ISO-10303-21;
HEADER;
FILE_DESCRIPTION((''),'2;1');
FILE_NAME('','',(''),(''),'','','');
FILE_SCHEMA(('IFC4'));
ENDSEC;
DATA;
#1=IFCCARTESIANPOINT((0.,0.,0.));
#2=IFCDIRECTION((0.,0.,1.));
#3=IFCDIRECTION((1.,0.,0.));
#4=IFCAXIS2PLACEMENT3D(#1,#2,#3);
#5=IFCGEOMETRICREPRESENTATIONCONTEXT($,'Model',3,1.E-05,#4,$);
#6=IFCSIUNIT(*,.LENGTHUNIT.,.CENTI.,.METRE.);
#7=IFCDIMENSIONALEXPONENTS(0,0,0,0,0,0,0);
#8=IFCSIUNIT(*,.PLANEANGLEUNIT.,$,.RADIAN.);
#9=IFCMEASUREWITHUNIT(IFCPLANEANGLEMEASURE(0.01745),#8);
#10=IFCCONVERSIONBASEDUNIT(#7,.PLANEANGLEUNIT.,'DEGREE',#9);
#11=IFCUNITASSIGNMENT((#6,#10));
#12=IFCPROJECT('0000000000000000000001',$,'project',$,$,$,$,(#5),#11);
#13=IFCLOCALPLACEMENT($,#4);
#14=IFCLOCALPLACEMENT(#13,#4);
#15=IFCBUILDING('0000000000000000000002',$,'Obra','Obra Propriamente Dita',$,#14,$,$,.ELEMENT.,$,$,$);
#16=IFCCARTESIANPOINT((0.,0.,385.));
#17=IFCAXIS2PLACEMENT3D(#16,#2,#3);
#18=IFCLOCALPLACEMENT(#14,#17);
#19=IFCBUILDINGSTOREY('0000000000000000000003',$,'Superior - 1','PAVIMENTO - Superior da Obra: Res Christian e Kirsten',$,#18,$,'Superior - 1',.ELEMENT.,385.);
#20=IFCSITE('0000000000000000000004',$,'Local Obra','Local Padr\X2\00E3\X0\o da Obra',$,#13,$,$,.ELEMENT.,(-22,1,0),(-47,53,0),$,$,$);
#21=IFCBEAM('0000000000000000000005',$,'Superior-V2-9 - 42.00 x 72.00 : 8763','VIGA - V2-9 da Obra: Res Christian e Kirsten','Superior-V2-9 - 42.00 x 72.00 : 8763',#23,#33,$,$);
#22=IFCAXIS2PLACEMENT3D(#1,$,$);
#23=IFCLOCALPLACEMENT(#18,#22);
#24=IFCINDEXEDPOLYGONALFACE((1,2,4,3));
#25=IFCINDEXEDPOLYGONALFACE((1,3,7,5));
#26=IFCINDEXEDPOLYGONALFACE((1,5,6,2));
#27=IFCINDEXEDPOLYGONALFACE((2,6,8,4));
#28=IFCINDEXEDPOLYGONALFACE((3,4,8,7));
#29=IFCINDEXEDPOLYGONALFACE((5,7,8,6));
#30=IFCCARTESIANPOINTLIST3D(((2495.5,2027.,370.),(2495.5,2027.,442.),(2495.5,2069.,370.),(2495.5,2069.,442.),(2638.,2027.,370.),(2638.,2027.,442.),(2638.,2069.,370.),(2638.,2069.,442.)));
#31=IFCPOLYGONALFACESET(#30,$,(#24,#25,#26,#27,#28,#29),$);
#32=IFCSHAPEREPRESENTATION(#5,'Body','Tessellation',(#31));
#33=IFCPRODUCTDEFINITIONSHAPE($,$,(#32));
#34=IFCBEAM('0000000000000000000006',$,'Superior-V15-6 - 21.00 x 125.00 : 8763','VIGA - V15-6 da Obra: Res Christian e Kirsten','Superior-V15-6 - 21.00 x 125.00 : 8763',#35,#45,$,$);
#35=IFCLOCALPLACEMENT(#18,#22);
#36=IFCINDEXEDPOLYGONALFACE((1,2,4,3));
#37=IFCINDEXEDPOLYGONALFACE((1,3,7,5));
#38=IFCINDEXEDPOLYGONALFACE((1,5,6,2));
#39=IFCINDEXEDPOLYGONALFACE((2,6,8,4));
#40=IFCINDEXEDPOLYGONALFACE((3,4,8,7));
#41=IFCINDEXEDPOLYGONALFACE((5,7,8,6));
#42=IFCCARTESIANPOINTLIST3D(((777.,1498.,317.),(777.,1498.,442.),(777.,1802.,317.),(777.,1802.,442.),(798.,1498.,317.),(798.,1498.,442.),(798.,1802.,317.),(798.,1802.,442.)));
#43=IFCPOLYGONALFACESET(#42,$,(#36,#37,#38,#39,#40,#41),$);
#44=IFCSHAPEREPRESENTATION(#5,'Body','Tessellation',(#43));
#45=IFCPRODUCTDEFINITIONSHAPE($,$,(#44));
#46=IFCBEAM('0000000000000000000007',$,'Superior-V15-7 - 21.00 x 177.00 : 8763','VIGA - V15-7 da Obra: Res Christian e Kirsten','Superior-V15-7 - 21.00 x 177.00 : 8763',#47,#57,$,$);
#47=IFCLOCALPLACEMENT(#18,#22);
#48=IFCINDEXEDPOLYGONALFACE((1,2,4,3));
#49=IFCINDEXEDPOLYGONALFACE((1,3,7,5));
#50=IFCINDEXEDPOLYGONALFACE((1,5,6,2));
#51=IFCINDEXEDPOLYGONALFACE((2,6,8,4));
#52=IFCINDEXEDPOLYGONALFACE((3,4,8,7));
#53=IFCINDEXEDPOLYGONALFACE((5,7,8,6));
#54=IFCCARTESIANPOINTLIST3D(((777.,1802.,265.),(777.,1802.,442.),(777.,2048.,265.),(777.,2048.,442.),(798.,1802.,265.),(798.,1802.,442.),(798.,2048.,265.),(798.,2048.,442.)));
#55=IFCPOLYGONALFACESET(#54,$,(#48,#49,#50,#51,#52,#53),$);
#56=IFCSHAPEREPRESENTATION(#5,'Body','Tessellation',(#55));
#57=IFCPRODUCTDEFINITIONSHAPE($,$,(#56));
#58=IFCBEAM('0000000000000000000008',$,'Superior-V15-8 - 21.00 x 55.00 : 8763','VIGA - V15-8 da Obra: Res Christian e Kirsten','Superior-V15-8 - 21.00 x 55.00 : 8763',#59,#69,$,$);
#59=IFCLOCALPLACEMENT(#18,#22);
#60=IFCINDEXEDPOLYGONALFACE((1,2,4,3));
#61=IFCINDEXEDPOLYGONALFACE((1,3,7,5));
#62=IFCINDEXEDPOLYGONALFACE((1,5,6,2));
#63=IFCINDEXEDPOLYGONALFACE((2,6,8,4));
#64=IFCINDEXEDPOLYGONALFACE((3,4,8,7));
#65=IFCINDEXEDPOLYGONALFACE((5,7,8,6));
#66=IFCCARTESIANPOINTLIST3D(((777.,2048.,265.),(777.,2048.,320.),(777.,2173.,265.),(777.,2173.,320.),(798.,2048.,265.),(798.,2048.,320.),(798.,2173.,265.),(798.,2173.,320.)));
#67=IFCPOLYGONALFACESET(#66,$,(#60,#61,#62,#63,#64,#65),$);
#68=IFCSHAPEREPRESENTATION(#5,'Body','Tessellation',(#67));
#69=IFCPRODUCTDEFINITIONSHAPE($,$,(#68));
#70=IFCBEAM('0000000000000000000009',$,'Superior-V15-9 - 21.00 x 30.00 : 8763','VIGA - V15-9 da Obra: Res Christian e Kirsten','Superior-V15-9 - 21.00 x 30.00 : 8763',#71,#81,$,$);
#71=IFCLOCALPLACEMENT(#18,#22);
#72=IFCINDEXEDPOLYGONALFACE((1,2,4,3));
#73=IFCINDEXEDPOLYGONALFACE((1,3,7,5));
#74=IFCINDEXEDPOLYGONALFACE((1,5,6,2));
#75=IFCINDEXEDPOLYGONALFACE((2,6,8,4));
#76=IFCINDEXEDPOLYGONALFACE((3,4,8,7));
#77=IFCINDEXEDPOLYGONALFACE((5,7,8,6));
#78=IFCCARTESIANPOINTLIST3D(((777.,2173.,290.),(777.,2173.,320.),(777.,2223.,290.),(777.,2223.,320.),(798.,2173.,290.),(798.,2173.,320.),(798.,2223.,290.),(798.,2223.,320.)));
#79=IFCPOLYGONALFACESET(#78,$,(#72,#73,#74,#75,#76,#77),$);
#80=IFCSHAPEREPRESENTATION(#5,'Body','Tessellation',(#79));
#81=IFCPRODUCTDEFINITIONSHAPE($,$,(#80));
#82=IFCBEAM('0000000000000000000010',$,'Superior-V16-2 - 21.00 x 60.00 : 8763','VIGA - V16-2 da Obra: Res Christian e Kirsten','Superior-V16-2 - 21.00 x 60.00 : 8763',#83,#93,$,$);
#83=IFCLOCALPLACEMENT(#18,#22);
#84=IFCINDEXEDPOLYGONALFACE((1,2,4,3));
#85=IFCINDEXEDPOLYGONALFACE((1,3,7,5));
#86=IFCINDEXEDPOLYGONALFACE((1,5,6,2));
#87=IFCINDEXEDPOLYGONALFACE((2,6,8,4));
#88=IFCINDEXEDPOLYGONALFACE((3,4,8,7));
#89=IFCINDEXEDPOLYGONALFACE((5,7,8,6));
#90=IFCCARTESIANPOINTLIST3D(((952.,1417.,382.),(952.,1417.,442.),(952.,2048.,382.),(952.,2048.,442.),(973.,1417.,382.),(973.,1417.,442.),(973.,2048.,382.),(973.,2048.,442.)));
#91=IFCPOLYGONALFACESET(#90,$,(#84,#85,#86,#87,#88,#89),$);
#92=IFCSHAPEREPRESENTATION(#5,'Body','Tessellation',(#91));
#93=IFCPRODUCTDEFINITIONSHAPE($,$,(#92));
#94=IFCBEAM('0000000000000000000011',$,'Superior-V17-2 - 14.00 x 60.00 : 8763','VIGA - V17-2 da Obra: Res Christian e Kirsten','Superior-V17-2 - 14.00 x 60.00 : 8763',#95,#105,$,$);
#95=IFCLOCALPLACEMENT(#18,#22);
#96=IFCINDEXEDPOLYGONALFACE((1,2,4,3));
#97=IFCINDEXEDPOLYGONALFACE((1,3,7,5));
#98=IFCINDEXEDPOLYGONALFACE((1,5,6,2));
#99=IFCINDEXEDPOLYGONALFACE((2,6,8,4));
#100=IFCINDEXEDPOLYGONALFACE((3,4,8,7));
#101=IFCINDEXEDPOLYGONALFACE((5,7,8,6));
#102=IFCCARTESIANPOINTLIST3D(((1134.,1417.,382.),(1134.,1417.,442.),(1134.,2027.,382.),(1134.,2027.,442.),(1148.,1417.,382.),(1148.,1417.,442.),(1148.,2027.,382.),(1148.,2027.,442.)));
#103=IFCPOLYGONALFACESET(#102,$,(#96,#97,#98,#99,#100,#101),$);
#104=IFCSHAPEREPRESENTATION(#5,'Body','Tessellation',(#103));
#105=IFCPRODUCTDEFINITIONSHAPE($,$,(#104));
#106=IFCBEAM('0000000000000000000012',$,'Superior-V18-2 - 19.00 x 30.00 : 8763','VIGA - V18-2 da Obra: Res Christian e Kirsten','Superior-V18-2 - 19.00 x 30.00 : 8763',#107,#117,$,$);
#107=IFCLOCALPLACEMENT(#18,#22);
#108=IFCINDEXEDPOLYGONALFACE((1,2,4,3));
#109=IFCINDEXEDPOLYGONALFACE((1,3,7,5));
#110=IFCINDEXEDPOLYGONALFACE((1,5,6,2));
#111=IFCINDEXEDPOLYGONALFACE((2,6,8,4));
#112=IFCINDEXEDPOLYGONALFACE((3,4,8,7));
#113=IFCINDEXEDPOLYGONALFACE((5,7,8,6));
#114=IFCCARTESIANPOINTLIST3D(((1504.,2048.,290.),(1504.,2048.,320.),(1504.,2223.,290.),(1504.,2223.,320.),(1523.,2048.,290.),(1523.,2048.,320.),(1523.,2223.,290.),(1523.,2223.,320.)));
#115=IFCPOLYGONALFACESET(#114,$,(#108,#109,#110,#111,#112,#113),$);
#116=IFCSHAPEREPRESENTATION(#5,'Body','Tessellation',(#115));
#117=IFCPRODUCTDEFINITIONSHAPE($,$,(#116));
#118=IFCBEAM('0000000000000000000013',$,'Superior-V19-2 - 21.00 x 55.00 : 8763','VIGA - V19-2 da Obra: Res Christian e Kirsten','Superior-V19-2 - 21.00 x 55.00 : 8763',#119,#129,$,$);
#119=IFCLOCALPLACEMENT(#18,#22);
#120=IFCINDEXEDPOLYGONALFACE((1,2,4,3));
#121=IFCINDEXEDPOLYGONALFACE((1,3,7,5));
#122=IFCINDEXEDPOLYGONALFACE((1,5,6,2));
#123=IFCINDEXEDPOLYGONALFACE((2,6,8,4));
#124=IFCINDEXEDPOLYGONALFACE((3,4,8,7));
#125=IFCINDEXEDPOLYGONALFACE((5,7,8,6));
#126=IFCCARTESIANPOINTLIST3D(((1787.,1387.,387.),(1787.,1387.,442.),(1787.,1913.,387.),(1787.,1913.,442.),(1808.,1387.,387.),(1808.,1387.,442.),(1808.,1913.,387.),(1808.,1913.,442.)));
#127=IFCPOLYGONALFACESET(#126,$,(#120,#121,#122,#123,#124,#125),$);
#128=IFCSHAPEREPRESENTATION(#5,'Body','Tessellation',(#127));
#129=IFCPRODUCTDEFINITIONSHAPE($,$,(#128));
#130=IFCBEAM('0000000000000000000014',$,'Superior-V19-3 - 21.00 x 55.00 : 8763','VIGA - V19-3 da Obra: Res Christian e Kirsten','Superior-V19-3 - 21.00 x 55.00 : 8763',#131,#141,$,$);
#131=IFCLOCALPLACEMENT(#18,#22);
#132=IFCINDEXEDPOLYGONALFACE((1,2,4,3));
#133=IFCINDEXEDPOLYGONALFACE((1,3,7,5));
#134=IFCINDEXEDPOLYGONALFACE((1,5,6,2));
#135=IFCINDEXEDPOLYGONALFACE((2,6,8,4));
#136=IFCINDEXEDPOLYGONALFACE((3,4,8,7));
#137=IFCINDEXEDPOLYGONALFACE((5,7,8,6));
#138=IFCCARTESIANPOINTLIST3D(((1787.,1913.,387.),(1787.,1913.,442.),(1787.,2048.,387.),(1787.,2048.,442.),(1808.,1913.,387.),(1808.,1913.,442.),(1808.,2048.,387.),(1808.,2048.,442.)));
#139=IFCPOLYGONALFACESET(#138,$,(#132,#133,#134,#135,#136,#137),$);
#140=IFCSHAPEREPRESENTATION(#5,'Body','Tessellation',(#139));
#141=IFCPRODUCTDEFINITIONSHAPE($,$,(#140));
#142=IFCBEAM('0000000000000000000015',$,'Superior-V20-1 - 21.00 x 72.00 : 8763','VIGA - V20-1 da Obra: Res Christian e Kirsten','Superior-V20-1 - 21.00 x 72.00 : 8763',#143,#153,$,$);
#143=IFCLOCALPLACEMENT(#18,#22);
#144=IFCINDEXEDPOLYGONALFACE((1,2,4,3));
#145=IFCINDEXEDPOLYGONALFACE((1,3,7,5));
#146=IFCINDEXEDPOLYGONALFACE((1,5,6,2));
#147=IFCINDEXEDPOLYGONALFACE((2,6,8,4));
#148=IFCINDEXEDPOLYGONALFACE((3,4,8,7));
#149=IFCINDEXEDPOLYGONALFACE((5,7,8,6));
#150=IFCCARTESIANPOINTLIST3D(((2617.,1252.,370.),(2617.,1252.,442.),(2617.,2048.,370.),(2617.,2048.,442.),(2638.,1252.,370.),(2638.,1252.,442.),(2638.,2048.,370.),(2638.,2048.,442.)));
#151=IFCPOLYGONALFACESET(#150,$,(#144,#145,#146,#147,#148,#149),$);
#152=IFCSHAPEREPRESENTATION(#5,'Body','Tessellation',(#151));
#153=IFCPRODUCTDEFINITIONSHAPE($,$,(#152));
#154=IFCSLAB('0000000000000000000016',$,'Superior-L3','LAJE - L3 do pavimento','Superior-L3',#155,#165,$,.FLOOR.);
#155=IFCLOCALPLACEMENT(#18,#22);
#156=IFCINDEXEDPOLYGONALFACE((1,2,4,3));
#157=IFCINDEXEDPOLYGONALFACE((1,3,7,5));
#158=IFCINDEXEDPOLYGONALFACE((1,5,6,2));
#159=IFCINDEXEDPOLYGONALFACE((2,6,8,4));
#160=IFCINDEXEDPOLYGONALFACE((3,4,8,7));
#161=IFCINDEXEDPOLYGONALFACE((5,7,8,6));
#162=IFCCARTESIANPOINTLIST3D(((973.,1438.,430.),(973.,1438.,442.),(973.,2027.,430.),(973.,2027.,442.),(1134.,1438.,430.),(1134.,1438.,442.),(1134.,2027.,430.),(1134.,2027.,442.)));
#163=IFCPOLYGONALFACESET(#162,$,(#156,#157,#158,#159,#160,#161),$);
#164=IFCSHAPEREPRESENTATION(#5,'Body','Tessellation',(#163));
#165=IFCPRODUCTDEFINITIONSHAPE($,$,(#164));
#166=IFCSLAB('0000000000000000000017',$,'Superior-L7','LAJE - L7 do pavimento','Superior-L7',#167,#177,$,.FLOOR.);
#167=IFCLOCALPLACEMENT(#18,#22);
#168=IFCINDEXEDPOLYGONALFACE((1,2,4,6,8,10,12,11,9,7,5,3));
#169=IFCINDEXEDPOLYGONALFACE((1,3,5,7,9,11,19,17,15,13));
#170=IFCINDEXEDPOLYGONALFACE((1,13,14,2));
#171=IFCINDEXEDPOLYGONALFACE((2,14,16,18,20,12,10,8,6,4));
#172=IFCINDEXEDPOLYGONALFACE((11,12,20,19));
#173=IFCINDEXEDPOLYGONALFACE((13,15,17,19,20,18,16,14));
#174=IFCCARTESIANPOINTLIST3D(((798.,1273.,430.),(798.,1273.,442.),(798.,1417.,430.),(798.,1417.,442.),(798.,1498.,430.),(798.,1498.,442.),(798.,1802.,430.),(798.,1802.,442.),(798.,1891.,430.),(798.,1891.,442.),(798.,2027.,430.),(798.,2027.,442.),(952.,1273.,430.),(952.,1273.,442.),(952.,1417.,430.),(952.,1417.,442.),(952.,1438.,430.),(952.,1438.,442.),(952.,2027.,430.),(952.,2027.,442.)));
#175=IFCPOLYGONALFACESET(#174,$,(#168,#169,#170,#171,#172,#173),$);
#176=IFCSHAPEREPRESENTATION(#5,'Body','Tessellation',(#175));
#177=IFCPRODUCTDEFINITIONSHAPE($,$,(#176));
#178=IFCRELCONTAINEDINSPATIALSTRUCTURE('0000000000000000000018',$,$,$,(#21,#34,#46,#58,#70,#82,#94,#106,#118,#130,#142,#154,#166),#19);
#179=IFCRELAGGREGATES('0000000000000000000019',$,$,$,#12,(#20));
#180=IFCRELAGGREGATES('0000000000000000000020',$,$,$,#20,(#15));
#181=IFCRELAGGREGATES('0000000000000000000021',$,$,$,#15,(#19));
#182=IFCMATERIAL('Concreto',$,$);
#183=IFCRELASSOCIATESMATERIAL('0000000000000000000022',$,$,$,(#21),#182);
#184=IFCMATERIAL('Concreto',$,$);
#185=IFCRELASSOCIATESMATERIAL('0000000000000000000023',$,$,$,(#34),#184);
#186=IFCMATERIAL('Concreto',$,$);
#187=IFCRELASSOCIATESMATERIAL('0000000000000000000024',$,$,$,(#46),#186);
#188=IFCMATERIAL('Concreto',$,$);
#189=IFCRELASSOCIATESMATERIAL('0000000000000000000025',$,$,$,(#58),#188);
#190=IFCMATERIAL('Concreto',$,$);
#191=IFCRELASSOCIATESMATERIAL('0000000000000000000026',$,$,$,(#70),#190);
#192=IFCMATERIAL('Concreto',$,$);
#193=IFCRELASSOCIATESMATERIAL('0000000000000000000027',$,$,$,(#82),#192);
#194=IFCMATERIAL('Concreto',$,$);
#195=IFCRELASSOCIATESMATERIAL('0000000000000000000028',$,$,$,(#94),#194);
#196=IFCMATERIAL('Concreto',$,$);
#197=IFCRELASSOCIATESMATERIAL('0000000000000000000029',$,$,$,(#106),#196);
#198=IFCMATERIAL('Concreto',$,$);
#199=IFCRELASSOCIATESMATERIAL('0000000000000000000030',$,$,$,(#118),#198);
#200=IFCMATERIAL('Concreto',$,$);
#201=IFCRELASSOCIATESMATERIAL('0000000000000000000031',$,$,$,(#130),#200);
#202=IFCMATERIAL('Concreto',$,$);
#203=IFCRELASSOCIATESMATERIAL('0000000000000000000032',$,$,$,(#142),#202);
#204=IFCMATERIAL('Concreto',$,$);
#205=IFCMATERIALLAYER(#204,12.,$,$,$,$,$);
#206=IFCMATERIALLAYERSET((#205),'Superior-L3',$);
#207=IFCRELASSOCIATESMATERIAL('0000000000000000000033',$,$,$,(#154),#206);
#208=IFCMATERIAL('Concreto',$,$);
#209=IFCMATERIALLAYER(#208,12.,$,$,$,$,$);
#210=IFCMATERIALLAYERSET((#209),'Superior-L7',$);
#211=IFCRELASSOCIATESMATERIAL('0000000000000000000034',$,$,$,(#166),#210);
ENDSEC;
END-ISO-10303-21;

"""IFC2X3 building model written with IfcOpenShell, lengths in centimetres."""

from ifc_helpers import new_model, entity, si_unit, converted_unit, frame, origin_with_axes, place, context, project, spatial, polyline, outline, extrude, material, layer, layer_set, layer_usage, element, save


model = new_model("IFC2X3")

# Units and contexts
model_context = context("Model", 3, precision=1e-05, world=origin_with_axes())
ifc_project = project(units=[si_unit("LENGTHUNIT", "METRE", prefix="CENTI"), converted_unit("PLANEANGLEUNIT", "DEGREE", entity("IfcPlaneAngleMeasure", 0.01745), si_unit("PLANEANGLEUNIT", "RADIAN"), dimensions=[0, 0, 0, 0, 0, 0, 0])], contexts=[model_context])

# Site, building, storey
site_placement = place(None, origin_with_axes())
site = spatial("IfcSite", under=ifc_project, at=site_placement, Name="Local Obra", Description="Local Padrão da Obra", CompositionType="ELEMENT", RefLatitude=(-22, 1, 0), RefLongitude=(-47, 53, 0))
building_placement = place(site_placement, origin_with_axes())
building = spatial("IfcBuilding", under=site, at=building_placement, Name="Obra", Description="Obra Propriamente Dita", CompositionType="ELEMENT")
storey_placement = place(building_placement, frame((0.0, 0.0, 385.0), z_axis=(0.0, 0.0, 1.0), x_axis=(1.0, 0.0, 0.0)))
storey = spatial("IfcBuildingStorey", under=building, at=storey_placement, Name="Superior - 1", Description="PAVIMENTO - Superior da Obra: Res Christian e Kirsten", LongName="Superior - 1", CompositionType="ELEMENT", Elevation=385.0)

# Beams
ifc_material_1 = material(Name="Concreto")
beam_1_placement = place(storey_placement, frame((2495.5, 2048.0, 442.0), z_axis=(1.0, 0.0, 0.0), x_axis=(0.0, -1.0, 0.0)))
element("IfcBeam", 1, at=beam_1_placement, inside=storey, material=ifc_material_1, Name="Superior-V2-9 - 42.00 x 72.00 : 8763", Description="VIGA - V2-9 da Obra: Res Christian e Kirsten", ObjectType="Superior-V2-9 - 42.00 x 72.00 : 8763", context=model_context, shape_type="SweptSolid", body=[
    extrude(outline(polyline([(-21.0, 0.0), (21.0, 0.0), (21.0, 72.0), (-21.0, 72.0), (-21.0, 0.0)])), origin_with_axes(), (0.0, 0.0, 1.0), 142.5),
])
ifc_material_2 = material(Name="Concreto")
beam_2_placement = place(storey_placement, frame((787.5, 1498.0, 442.0), z_axis=(0.0, 1.0, 0.0), x_axis=(1.0, 0.0, 0.0)))
element("IfcBeam", 2, at=beam_2_placement, inside=storey, material=ifc_material_2, Name="Superior-V15-6 - 21.00 x 125.00 : 8763", Description="VIGA - V15-6 da Obra: Res Christian e Kirsten", ObjectType="Superior-V15-6 - 21.00 x 125.00 : 8763", context=model_context, shape_type="SweptSolid", body=[
    extrude(outline(polyline([(-10.5, 0.0), (10.5, 0.0), (10.5, 125.0), (-10.5, 125.0), (-10.5, 0.0)])), origin_with_axes(), (0.0, 0.0, 1.0), 304.0),
])
ifc_material_3 = material(Name="Concreto")
beam_3_placement = place(storey_placement, frame((787.5, 1802.0, 442.0), z_axis=(0.0, 1.0, 0.0), x_axis=(1.0, 0.0, 0.0)))
element("IfcBeam", 3, at=beam_3_placement, inside=storey, material=ifc_material_3, Name="Superior-V15-7 - 21.00 x 177.00 : 8763", Description="VIGA - V15-7 da Obra: Res Christian e Kirsten", ObjectType="Superior-V15-7 - 21.00 x 177.00 : 8763", context=model_context, shape_type="SweptSolid", body=[
    extrude(outline(polyline([(-10.5, 0.0), (10.5, 0.0), (10.5, 177.0), (-10.5, 177.0), (-10.5, 0.0)])), origin_with_axes(), (0.0, 0.0, 1.0), 246.0),
])
ifc_material_4 = material(Name="Concreto")
beam_4_placement = place(storey_placement, frame((787.5, 2048.0, 320.0), z_axis=(0.0, 1.0, 0.0), x_axis=(1.0, 0.0, 0.0)))
element("IfcBeam", 4, at=beam_4_placement, inside=storey, material=ifc_material_4, Name="Superior-V15-8 - 21.00 x 55.00 : 8763", Description="VIGA - V15-8 da Obra: Res Christian e Kirsten", ObjectType="Superior-V15-8 - 21.00 x 55.00 : 8763", context=model_context, shape_type="SweptSolid", body=[
    extrude(outline(polyline([(-10.5, 0.0), (10.5, 0.0), (10.5, 55.0), (-10.5, 55.0), (-10.5, 0.0)])), origin_with_axes(), (0.0, 0.0, 1.0), 125.0),
])
ifc_material_5 = material(Name="Concreto")
beam_5_placement = place(storey_placement, frame((787.5, 2173.0, 320.0), z_axis=(0.0, 1.0, 0.0), x_axis=(1.0, 0.0, 0.0)))
element("IfcBeam", 5, at=beam_5_placement, inside=storey, material=ifc_material_5, Name="Superior-V15-9 - 21.00 x 30.00 : 8763", Description="VIGA - V15-9 da Obra: Res Christian e Kirsten", ObjectType="Superior-V15-9 - 21.00 x 30.00 : 8763", context=model_context, shape_type="SweptSolid", body=[
    extrude(outline(polyline([(-10.5, 0.0), (10.5, 0.0), (10.5, 30.0), (-10.5, 30.0), (-10.5, 0.0)])), origin_with_axes(), (0.0, 0.0, 1.0), 50.0),
])
ifc_material_6 = material(Name="Concreto")
beam_6_placement = place(storey_placement, frame((952.0, 1417.0, 442.0), z_axis=(0.0, 1.0, 0.0), x_axis=(1.0, 0.0, 0.0)))
element("IfcBeam", 6, at=beam_6_placement, inside=storey, material=ifc_material_6, Name="Superior-V16-2 - 21.00 x 60.00 : 8763", Description="VIGA - V16-2 da Obra: Res Christian e Kirsten", ObjectType="Superior-V16-2 - 21.00 x 60.00 : 8763", context=model_context, shape_type="SweptSolid", body=[
    extrude(outline(polyline([(0.0, 0.0), (21.0, 0.0), (21.0, 60.0), (0.0, 60.0), (0.0, 0.0)])), origin_with_axes(), (0.0, 0.0, 1.0), 631.0),
])
ifc_material_7 = material(Name="Concreto")
beam_7_placement = place(storey_placement, frame((1148.0, 1417.0, 442.0), z_axis=(0.0, 1.0, 0.0), x_axis=(1.0, 0.0, 0.0)))
element("IfcBeam", 7, at=beam_7_placement, inside=storey, material=ifc_material_7, Name="Superior-V17-2 - 14.00 x 60.00 : 8763", Description="VIGA - V17-2 da Obra: Res Christian e Kirsten", ObjectType="Superior-V17-2 - 14.00 x 60.00 : 8763", context=model_context, shape_type="SweptSolid", body=[
    extrude(outline(polyline([(-14.0, 0.0), (0.0, 0.0), (0.0, 60.0), (-14.0, 60.0), (-14.0, 0.0)])), origin_with_axes(), (0.0, 0.0, 1.0), 610.0),
])
ifc_material_8 = material(Name="Concreto")
beam_8_placement = place(storey_placement, frame((1523.0, 2048.0, 320.0), z_axis=(0.0, 1.0, 0.0), x_axis=(1.0, 0.0, 0.0)))
element("IfcBeam", 8, at=beam_8_placement, inside=storey, material=ifc_material_8, Name="Superior-V18-2 - 19.00 x 30.00 : 8763", Description="VIGA - V18-2 da Obra: Res Christian e Kirsten", ObjectType="Superior-V18-2 - 19.00 x 30.00 : 8763", context=model_context, shape_type="SweptSolid", body=[
    extrude(outline(polyline([(-19.0, 0.0), (0.0, 0.0), (0.0, 30.0), (-19.0, 30.0), (-19.0, 0.0)])), origin_with_axes(), (0.0, 0.0, 1.0), 175.0),
])
ifc_material_9 = material(Name="Concreto")
beam_9_placement = place(storey_placement, frame((1808.0, 1387.0, 442.0), z_axis=(0.0, 1.0, 0.0), x_axis=(1.0, 0.0, 0.0)))
element("IfcBeam", 9, at=beam_9_placement, inside=storey, material=ifc_material_9, Name="Superior-V19-2 - 21.00 x 55.00 : 8763", Description="VIGA - V19-2 da Obra: Res Christian e Kirsten", ObjectType="Superior-V19-2 - 21.00 x 55.00 : 8763", context=model_context, shape_type="SweptSolid", body=[
    extrude(outline(polyline([(-21.0, 0.0), (0.0, 0.0), (0.0, 55.0), (-21.0, 55.0), (-21.0, 0.0)])), origin_with_axes(), (0.0, 0.0, 1.0), 526.0),
])
ifc_material_10 = material(Name="Concreto")
beam_10_placement = place(storey_placement, frame((1808.0, 1913.0, 442.0), z_axis=(0.0, 1.0, 0.0), x_axis=(1.0, 0.0, 0.0)))
element("IfcBeam", 10, at=beam_10_placement, inside=storey, material=ifc_material_10, Name="Superior-V19-3 - 21.00 x 55.00 : 8763", Description="VIGA - V19-3 da Obra: Res Christian e Kirsten", ObjectType="Superior-V19-3 - 21.00 x 55.00 : 8763", context=model_context, shape_type="SweptSolid", body=[
    extrude(outline(polyline([(-21.0, 0.0), (0.0, 0.0), (0.0, 55.0), (-21.0, 55.0), (-21.0, 0.0)])), origin_with_axes(), (0.0, 0.0, 1.0), 135.0),
])
ifc_material_11 = material(Name="Concreto")
beam_11_placement = place(storey_placement, frame((2638.0, 1252.0, 442.0), z_axis=(0.0, 1.0, 0.0), x_axis=(1.0, 0.0, 0.0)))
element("IfcBeam", 11, at=beam_11_placement, inside=storey, material=ifc_material_11, Name="Superior-V20-1 - 21.00 x 72.00 : 8763", Description="VIGA - V20-1 da Obra: Res Christian e Kirsten", ObjectType="Superior-V20-1 - 21.00 x 72.00 : 8763", context=model_context, shape_type="SweptSolid", body=[
    extrude(outline(polyline([(-21.0, 0.0), (0.0, 0.0), (0.0, 72.0), (-21.0, 72.0), (-21.0, 0.0)])), origin_with_axes(), (0.0, 0.0, 1.0), 796.0),
])

# Slabs
ifc_material_12 = material(Name="Concreto")
ifc_layer_1 = layer(ifc_material_12, 12.0)
ifc_layer_set_1 = layer_set([ifc_layer_1], Name="Superior-L3")
ifc_layer_usage_1 = layer_usage(ifc_layer_set_1, "AXIS3", "POSITIVE", 0.0)
slab_1_placement = place(storey_placement, frame((1134.0, 1438.0, 430.0), z_axis=(0.0, 0.0, 1.0), x_axis=(1.0, 0.0, 0.0)))
element("IfcSlab", 12, at=slab_1_placement, inside=storey, material=ifc_layer_usage_1, Name="Superior-L3", Description="LAJE - L3 do pavimento", ObjectType="Superior-L3", PredefinedType="FLOOR", context=model_context, shape_type="SweptSolid", body=[
    extrude(outline(polyline([(0.0, 589.0), (-161.0, 589.0), (-161.0, 0.0), (0.0, 0.0), (0.0, 589.0)])), origin_with_axes(), (0.0, 0.0, 1.0), 12.0),
])
ifc_material_13 = material(Name="Concreto")
ifc_layer_2 = layer(ifc_material_13, 12.0)
ifc_layer_set_2 = layer_set([ifc_layer_2], Name="Superior-L7")
ifc_layer_usage_2 = layer_usage(ifc_layer_set_2, "AXIS3", "POSITIVE", 0.0)
slab_2_placement = place(storey_placement, frame((952.0, 1438.0, 430.0), z_axis=(0.0, 0.0, 1.0), x_axis=(1.0, 0.0, 0.0)))
element("IfcSlab", 13, at=slab_2_placement, inside=storey, material=ifc_layer_usage_2, Name="Superior-L7", Description="LAJE - L7 do pavimento", ObjectType="Superior-L7", PredefinedType="FLOOR", context=model_context, shape_type="SweptSolid", body=[
    extrude(outline(polyline([(0.0, 589.0), (-154.0, 589.0), (-154.0, 453.0), (-154.0, 364.0), (-154.0, 60.0), (-154.0, -21.0), (-154.0, -165.0), (0.0, -165.0), (0.0, -21.0), (0.0, 0.0), (0.0, 589.0)])), origin_with_axes(), (0.0, 0.0, 1.0), 12.0),
])

save(model, "model.ifc")
